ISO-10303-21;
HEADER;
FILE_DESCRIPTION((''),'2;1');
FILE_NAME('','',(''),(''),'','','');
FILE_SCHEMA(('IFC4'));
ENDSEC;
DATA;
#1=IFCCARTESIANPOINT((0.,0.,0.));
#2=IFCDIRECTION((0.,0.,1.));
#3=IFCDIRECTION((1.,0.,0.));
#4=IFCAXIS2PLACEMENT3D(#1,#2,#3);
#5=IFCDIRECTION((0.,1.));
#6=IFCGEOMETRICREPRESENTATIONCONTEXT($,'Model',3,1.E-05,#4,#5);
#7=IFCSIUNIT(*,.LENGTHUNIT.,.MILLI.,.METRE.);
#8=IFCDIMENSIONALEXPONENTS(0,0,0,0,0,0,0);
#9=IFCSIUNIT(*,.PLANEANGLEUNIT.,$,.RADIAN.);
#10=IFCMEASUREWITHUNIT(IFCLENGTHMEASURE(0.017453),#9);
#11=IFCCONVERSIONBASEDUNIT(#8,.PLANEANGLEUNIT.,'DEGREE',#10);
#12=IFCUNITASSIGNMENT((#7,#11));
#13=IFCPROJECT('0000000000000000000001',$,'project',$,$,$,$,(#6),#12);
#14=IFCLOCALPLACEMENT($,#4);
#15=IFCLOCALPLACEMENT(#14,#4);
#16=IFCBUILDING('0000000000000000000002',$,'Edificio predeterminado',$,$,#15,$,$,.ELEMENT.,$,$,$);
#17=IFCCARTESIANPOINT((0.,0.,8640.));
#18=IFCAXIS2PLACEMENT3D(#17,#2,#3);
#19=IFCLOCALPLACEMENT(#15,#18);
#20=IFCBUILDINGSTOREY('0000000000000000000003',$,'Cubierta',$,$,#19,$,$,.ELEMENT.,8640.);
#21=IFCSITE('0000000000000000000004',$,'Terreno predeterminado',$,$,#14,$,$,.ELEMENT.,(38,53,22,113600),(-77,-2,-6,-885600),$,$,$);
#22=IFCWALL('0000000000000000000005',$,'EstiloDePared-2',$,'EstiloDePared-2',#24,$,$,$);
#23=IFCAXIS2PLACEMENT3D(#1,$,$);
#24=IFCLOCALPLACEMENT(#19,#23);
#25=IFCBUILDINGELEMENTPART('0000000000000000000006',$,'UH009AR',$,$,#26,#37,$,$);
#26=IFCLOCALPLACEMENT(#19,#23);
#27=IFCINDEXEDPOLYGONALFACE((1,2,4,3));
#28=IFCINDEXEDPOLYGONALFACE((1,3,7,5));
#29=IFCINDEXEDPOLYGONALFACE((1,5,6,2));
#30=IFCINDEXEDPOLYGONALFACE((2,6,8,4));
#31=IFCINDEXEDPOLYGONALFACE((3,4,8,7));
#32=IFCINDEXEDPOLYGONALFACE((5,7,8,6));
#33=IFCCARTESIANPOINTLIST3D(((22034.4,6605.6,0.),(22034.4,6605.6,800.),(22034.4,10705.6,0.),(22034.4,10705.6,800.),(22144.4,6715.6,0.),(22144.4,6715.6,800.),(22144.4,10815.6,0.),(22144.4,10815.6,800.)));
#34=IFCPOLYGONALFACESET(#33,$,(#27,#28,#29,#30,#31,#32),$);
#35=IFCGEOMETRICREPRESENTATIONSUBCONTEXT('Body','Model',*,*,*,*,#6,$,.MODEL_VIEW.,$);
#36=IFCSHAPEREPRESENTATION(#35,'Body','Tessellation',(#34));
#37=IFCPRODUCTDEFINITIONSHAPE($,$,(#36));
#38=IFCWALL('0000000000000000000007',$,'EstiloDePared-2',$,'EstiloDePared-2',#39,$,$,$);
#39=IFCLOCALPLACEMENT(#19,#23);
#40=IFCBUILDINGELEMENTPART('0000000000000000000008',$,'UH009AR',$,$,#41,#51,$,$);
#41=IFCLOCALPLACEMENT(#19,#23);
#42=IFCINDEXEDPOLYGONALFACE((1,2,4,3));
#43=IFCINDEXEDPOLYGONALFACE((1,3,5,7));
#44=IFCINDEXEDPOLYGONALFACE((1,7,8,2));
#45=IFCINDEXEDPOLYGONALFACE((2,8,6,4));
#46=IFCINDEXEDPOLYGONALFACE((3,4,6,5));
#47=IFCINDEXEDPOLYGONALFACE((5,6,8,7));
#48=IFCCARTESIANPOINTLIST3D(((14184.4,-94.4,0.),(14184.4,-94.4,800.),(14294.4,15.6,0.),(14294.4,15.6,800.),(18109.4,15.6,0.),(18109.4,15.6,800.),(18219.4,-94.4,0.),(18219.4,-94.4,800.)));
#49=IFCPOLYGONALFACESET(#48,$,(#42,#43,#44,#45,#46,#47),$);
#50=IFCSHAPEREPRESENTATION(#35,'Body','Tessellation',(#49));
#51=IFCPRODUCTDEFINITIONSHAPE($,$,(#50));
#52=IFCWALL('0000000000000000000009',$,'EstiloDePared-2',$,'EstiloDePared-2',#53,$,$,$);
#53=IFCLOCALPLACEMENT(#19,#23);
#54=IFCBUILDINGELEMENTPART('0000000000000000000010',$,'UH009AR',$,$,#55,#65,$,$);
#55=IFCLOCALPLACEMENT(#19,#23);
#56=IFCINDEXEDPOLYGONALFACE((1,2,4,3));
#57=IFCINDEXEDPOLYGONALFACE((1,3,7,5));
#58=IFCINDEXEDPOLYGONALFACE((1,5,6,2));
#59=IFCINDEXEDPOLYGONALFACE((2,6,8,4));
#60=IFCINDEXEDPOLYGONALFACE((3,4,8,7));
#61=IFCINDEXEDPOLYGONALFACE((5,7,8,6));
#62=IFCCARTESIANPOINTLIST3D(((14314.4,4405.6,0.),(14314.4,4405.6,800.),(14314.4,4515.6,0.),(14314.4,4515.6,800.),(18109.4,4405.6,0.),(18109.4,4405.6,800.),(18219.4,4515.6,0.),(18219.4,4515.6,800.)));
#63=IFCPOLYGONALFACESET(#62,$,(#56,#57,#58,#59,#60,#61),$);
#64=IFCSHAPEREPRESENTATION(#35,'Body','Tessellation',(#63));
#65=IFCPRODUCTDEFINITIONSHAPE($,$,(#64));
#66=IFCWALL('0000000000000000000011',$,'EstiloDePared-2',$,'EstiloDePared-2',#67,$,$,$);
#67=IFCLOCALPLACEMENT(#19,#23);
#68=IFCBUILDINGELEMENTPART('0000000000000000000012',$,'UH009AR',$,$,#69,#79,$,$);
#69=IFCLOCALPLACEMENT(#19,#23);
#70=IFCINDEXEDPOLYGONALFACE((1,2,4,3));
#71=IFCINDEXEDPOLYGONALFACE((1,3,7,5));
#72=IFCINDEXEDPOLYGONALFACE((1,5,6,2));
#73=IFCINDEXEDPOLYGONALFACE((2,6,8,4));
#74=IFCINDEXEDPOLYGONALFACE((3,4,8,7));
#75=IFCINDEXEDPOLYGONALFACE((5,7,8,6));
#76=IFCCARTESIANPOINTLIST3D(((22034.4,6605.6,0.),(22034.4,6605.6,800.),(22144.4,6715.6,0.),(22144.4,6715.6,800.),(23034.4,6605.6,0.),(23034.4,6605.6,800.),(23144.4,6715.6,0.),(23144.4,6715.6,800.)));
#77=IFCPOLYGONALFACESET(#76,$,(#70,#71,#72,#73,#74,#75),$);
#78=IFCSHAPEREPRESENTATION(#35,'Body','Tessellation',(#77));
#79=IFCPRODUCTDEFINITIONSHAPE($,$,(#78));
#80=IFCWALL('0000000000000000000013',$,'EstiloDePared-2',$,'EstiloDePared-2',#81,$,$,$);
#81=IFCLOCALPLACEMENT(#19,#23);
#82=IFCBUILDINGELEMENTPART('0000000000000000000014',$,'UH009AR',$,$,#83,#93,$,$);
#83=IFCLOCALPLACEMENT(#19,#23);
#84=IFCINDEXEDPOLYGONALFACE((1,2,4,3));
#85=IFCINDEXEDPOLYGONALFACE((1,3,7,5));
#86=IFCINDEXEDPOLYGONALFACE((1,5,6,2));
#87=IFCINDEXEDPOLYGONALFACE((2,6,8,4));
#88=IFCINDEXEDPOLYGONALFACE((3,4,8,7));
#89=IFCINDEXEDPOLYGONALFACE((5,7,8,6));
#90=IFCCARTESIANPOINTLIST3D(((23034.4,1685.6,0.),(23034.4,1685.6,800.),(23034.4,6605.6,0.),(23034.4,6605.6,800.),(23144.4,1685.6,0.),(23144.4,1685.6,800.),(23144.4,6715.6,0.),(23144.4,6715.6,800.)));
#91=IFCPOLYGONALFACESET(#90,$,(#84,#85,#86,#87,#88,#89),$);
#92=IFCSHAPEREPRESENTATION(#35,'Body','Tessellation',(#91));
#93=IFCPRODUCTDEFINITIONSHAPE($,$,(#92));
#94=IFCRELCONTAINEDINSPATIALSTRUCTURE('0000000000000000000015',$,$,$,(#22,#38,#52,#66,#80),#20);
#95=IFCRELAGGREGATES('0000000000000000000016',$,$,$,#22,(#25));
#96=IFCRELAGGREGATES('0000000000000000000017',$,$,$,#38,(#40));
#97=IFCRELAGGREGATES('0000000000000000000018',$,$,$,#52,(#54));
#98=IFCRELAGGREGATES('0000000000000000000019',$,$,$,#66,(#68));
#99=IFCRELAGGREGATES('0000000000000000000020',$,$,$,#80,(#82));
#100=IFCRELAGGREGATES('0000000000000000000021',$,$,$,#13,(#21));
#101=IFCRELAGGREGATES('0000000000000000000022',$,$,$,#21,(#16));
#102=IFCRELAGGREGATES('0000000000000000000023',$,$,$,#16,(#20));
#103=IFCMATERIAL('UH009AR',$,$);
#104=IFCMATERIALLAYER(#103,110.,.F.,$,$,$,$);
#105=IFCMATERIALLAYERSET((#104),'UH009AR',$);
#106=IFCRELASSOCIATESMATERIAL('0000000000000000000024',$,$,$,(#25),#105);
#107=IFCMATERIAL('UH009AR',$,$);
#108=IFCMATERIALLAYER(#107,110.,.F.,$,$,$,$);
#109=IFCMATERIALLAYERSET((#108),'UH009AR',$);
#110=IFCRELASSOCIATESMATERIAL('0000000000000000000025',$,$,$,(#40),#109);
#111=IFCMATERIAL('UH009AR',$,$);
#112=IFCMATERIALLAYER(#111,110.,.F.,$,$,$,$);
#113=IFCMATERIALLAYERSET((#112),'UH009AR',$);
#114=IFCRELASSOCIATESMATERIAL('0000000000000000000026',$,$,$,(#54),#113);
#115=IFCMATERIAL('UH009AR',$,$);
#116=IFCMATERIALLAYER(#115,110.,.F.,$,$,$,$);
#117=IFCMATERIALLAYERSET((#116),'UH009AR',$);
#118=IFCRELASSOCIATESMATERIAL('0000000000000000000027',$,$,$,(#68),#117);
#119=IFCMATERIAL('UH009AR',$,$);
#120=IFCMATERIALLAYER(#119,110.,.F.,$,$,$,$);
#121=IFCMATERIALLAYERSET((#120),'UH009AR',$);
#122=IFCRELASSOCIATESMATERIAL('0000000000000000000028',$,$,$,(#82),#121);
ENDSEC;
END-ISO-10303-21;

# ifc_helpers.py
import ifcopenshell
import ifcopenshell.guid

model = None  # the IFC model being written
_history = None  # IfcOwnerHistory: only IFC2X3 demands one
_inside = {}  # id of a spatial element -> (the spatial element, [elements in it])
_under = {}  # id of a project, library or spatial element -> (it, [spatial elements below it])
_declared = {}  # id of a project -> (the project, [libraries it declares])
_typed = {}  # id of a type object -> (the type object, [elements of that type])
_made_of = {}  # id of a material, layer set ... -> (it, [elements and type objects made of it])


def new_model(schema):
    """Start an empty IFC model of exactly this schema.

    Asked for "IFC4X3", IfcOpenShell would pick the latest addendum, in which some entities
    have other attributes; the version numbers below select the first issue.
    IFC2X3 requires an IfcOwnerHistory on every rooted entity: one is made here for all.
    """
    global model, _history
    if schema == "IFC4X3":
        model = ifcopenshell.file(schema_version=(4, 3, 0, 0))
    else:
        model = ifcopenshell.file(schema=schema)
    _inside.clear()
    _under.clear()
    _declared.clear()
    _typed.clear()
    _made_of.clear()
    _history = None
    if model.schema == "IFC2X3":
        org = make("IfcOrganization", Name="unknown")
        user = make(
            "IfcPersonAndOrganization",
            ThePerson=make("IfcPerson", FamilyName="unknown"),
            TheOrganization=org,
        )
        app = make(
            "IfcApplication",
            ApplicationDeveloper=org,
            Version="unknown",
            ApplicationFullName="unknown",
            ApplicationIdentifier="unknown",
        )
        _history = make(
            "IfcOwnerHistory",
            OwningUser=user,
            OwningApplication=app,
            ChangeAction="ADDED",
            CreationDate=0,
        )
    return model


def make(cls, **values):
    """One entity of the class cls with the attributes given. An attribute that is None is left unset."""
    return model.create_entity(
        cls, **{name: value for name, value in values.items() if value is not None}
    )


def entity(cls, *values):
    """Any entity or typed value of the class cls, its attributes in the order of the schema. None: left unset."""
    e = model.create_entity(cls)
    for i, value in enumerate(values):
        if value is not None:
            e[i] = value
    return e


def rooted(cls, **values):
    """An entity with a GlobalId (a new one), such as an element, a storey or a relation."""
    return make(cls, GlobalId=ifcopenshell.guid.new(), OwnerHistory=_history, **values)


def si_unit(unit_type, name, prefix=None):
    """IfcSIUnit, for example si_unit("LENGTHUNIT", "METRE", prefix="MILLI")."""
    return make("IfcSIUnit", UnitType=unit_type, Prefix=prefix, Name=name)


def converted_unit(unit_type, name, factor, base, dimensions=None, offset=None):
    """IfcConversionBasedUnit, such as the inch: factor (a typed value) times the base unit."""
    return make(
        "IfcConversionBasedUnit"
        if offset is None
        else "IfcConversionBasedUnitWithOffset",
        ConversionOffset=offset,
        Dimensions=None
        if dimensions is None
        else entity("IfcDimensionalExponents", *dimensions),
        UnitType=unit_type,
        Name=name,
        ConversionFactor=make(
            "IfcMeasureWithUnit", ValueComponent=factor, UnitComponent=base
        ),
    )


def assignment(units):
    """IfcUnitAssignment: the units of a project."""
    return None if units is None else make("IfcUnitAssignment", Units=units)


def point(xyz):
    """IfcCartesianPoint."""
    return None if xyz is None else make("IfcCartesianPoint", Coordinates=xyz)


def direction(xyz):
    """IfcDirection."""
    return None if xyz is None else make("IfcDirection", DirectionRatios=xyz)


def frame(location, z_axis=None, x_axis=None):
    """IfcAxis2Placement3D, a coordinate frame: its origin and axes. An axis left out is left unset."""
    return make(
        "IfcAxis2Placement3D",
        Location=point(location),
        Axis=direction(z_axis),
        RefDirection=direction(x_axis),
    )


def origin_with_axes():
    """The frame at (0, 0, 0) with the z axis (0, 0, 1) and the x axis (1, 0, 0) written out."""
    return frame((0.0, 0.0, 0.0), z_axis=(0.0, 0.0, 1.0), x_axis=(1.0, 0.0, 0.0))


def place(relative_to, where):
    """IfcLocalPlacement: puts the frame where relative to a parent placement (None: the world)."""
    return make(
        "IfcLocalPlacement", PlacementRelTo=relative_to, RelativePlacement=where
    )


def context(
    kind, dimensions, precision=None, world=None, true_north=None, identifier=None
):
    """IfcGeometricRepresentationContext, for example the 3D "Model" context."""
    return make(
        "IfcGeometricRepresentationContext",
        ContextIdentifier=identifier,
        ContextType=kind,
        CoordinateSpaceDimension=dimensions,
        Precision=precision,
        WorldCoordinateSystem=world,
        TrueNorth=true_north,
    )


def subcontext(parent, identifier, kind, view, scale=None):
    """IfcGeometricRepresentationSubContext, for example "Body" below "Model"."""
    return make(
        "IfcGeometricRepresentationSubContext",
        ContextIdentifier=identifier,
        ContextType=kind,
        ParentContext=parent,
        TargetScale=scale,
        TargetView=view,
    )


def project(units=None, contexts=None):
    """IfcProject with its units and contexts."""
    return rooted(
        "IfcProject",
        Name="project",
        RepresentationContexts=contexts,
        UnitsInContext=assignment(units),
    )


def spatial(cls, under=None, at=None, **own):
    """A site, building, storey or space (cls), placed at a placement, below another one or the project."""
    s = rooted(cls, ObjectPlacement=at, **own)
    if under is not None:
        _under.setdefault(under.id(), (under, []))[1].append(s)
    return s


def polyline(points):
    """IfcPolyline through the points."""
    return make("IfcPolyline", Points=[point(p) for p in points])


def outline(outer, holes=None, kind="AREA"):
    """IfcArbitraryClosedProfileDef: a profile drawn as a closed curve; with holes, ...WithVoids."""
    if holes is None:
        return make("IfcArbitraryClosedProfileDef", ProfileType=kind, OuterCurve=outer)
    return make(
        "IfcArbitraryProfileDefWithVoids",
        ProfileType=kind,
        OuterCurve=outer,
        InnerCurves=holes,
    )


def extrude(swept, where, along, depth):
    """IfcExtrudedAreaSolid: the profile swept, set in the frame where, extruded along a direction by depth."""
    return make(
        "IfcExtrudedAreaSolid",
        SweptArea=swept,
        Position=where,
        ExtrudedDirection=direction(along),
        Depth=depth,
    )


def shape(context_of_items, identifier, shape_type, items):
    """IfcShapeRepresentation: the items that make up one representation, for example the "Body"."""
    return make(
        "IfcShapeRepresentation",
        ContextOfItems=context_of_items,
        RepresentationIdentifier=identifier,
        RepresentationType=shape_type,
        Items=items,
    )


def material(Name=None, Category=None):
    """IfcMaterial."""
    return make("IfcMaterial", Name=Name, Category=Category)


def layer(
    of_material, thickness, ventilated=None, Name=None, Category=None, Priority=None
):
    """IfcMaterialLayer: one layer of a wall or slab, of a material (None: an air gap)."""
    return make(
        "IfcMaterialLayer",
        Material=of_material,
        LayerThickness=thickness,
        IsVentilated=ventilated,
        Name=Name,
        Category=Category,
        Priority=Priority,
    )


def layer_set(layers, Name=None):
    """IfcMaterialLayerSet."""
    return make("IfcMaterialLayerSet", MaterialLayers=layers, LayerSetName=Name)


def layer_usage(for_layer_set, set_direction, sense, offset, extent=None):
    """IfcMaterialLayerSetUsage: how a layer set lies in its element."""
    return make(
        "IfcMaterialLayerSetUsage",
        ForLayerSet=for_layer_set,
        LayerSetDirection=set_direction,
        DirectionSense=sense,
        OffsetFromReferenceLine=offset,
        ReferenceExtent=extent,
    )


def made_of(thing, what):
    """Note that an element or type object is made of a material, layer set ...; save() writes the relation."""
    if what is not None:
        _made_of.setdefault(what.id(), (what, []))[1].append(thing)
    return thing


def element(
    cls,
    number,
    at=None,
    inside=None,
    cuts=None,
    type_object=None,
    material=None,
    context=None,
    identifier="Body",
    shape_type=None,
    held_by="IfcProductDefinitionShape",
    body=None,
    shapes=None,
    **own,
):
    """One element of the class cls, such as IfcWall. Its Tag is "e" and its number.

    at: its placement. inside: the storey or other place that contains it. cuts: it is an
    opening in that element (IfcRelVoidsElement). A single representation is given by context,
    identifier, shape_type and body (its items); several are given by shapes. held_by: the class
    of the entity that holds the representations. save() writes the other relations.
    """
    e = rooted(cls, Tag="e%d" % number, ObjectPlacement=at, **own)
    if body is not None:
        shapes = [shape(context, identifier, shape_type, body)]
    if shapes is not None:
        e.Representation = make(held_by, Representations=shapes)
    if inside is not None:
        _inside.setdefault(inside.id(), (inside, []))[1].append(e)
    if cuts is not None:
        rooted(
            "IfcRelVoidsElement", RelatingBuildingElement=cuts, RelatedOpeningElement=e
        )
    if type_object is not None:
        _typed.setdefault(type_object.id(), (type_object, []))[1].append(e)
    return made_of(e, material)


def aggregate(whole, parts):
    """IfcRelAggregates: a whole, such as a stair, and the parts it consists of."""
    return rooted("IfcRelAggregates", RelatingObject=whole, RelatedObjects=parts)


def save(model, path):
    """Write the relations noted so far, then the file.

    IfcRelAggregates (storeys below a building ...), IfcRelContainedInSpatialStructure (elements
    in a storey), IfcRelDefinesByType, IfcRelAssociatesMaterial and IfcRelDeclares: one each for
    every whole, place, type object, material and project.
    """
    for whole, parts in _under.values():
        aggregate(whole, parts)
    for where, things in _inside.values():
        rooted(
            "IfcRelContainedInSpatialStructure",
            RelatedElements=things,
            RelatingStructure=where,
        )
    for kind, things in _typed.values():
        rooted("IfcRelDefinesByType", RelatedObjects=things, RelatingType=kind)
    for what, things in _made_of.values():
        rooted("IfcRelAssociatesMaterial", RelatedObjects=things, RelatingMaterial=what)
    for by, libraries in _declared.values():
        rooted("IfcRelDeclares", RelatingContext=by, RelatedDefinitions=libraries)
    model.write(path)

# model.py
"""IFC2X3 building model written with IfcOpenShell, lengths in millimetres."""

from ifc_helpers import new_model, entity, si_unit, converted_unit, direction, frame, origin_with_axes, place, context, subcontext, project, spatial, polyline, outline, extrude, material, layer, layer_set, layer_usage, element, aggregate, save


model = new_model("IFC2X3")

# Units and contexts
model_context = context("Model", 3, precision=1e-05, world=origin_with_axes(), true_north=direction((0.0, 1.0)))
body_context = subcontext(model_context, "Body", "Model", "MODEL_VIEW")
ifc_project = project(units=[si_unit("LENGTHUNIT", "METRE", prefix="MILLI"), converted_unit("PLANEANGLEUNIT", "DEGREE", entity("IfcLengthMeasure", 0.017453), si_unit("PLANEANGLEUNIT", "RADIAN"), dimensions=[0, 0, 0, 0, 0, 0, 0])], contexts=[model_context])

# Site, building, storey
site_placement = place(None, origin_with_axes())
site = spatial("IfcSite", under=ifc_project, at=site_placement, Name="Terreno predeterminado", CompositionType="ELEMENT", RefLatitude=(38, 53, 22, 113600), RefLongitude=(-77, -2, -6, -885600))
building_placement = place(site_placement, origin_with_axes())
building = spatial("IfcBuilding", under=site, at=building_placement, Name="Edificio predeterminado", CompositionType="ELEMENT")
storey_placement = place(building_placement, frame((0.0, 0.0, 8640.0), z_axis=(0.0, 0.0, 1.0), x_axis=(1.0, 0.0, 0.0)))
storey = spatial("IfcBuildingStorey", under=building, at=storey_placement, Name="Cubierta", CompositionType="ELEMENT", Elevation=8640.0)

# Wall, building element part
wall_1_placement = place(storey_placement, frame((22089.4, 10760.6, 0.0), z_axis=(0.0, 0.0, 1.0), x_axis=(0.0, -1.0, 0.0)))
wall_1 = element("IfcWall", 1, at=wall_1_placement, inside=storey, Name="EstiloDePared-2", ObjectType="EstiloDePared-2")
ifc_material_1 = material(Name="UH009AR")
ifc_layer_1 = layer(ifc_material_1, 110.0, ventilated=False)
ifc_layer_set_1 = layer_set([ifc_layer_1], Name="UH009AR")
ifc_layer_usage_1 = layer_usage(ifc_layer_set_1, "AXIS2", "NEGATIVE", -55.0)
building_element_part_1_placement = place(wall_1_placement, origin_with_axes())
building_element_part_1 = element("IfcBuildingElementPart", 2, at=building_element_part_1_placement, material=ifc_layer_usage_1, Name="UH009AR", context=body_context, shape_type="SweptSolid", body=[
    extrude(outline(polyline([(4045.0, 55.0), (4155.0, -55.0), (55.0, -55.0), (-55.0, 55.0), (4045.0, 55.0)])), origin_with_axes(), (0.0, 0.0, 1.0), 800.0),
])
aggregate(wall_1, [building_element_part_1])

# Walls, building element parts
wall_2_placement = place(storey_placement, frame((18164.4, -39.4, 0.0), z_axis=(0.0, 0.0, 1.0), x_axis=(-1.0, 0.0, 0.0)))
wall_2 = element("IfcWall", 3, at=wall_2_placement, inside=storey, Name="EstiloDePared-2", ObjectType="EstiloDePared-2")
ifc_material_2 = material(Name="UH009AR")
ifc_layer_2 = layer(ifc_material_2, 110.0, ventilated=False)
ifc_layer_set_2 = layer_set([ifc_layer_2], Name="UH009AR")
ifc_layer_usage_2 = layer_usage(ifc_layer_set_2, "AXIS2", "NEGATIVE", -55.0)
building_element_part_2_placement = place(wall_2_placement, origin_with_axes())
building_element_part_2 = element("IfcBuildingElementPart", 4, at=building_element_part_2_placement, material=ifc_layer_usage_2, Name="UH009AR", context=body_context, shape_type="SweptSolid", body=[
    extrude(outline(polyline([(3980.0, 55.0), (3870.0, -55.0), (55.0, -55.0), (-55.0, 55.0), (3980.0, 55.0)])), origin_with_axes(), (0.0, 0.0, 1.0), 800.0),
])
aggregate(wall_2, [building_element_part_2])
wall_3_placement = place(storey_placement, frame((18164.4, 4460.6, 0.0), z_axis=(0.0, 0.0, 1.0), x_axis=(-1.0, 0.0, 0.0)))
wall_3 = element("IfcWall", 5, at=wall_3_placement, inside=storey, Name="EstiloDePared-2", ObjectType="EstiloDePared-2")
ifc_material_3 = material(Name="UH009AR")
ifc_layer_3 = layer(ifc_material_3, 110.0, ventilated=False)
ifc_layer_set_3 = layer_set([ifc_layer_3], Name="UH009AR")
ifc_layer_usage_3 = layer_usage(ifc_layer_set_3, "AXIS2", "NEGATIVE", -55.0)
building_element_part_3_placement = place(wall_3_placement, origin_with_axes())
building_element_part_3 = element("IfcBuildingElementPart", 6, at=building_element_part_3_placement, material=ifc_layer_usage_3, Name="UH009AR", context=body_context, shape_type="SweptSolid", body=[
    extrude(outline(polyline([(3850.0, 55.0), (3850.0, -55.0), (-55.0, -55.0), (55.0, 55.0), (3850.0, 55.0)])), origin_with_axes(), (0.0, 0.0, 1.0), 800.0),
])
aggregate(wall_3, [building_element_part_3])
wall_4_placement = place(storey_placement, frame((22089.4, 6660.6, 0.0), z_axis=(0.0, 0.0, 1.0), x_axis=(1.0, 0.0, 0.0)))
wall_4 = element("IfcWall", 7, at=wall_4_placement, inside=storey, Name="EstiloDePared-2", ObjectType="EstiloDePared-2")
ifc_material_4 = material(Name="UH009AR")
ifc_layer_4 = layer(ifc_material_4, 110.0, ventilated=False)
ifc_layer_set_4 = layer_set([ifc_layer_4], Name="UH009AR")
ifc_layer_usage_4 = layer_usage(ifc_layer_set_4, "AXIS2", "NEGATIVE", -55.0)
building_element_part_4_placement = place(wall_4_placement, origin_with_axes())
building_element_part_4 = element("IfcBuildingElementPart", 8, at=building_element_part_4_placement, material=ifc_layer_usage_4, Name="UH009AR", context=body_context, shape_type="SweptSolid", body=[
    extrude(outline(polyline([(1055.0, 55.0), (945.0, -55.0), (-55.0, -55.0), (55.0, 55.0), (1055.0, 55.0)])), origin_with_axes(), (0.0, 0.0, 1.0), 800.0),
])
aggregate(wall_4, [building_element_part_4])
wall_5_placement = place(storey_placement, frame((23089.4, 6660.6, 0.0), z_axis=(0.0, 0.0, 1.0), x_axis=(0.0, -1.0, 0.0)))
wall_5 = element("IfcWall", 9, at=wall_5_placement, inside=storey, Name="EstiloDePared-2", ObjectType="EstiloDePared-2")
ifc_material_5 = material(Name="UH009AR")
ifc_layer_5 = layer(ifc_material_5, 110.0, ventilated=False)
ifc_layer_set_5 = layer_set([ifc_layer_5], Name="UH009AR")
ifc_layer_usage_5 = layer_usage(ifc_layer_set_5, "AXIS2", "NEGATIVE", -55.0)
building_element_part_5_placement = place(wall_5_placement, origin_with_axes())
building_element_part_5 = element("IfcBuildingElementPart", 10, at=building_element_part_5_placement, material=ifc_layer_usage_5, Name="UH009AR", context=body_context, shape_type="SweptSolid", body=[
    extrude(outline(polyline([(4975.0, 55.0), (4975.0, -55.0), (55.0, -55.0), (-55.0, 55.0), (4975.0, 55.0)])), origin_with_axes(), (0.0, 0.0, 1.0), 800.0),
])
aggregate(wall_5, [building_element_part_5])

save(model, "model.ifc")
